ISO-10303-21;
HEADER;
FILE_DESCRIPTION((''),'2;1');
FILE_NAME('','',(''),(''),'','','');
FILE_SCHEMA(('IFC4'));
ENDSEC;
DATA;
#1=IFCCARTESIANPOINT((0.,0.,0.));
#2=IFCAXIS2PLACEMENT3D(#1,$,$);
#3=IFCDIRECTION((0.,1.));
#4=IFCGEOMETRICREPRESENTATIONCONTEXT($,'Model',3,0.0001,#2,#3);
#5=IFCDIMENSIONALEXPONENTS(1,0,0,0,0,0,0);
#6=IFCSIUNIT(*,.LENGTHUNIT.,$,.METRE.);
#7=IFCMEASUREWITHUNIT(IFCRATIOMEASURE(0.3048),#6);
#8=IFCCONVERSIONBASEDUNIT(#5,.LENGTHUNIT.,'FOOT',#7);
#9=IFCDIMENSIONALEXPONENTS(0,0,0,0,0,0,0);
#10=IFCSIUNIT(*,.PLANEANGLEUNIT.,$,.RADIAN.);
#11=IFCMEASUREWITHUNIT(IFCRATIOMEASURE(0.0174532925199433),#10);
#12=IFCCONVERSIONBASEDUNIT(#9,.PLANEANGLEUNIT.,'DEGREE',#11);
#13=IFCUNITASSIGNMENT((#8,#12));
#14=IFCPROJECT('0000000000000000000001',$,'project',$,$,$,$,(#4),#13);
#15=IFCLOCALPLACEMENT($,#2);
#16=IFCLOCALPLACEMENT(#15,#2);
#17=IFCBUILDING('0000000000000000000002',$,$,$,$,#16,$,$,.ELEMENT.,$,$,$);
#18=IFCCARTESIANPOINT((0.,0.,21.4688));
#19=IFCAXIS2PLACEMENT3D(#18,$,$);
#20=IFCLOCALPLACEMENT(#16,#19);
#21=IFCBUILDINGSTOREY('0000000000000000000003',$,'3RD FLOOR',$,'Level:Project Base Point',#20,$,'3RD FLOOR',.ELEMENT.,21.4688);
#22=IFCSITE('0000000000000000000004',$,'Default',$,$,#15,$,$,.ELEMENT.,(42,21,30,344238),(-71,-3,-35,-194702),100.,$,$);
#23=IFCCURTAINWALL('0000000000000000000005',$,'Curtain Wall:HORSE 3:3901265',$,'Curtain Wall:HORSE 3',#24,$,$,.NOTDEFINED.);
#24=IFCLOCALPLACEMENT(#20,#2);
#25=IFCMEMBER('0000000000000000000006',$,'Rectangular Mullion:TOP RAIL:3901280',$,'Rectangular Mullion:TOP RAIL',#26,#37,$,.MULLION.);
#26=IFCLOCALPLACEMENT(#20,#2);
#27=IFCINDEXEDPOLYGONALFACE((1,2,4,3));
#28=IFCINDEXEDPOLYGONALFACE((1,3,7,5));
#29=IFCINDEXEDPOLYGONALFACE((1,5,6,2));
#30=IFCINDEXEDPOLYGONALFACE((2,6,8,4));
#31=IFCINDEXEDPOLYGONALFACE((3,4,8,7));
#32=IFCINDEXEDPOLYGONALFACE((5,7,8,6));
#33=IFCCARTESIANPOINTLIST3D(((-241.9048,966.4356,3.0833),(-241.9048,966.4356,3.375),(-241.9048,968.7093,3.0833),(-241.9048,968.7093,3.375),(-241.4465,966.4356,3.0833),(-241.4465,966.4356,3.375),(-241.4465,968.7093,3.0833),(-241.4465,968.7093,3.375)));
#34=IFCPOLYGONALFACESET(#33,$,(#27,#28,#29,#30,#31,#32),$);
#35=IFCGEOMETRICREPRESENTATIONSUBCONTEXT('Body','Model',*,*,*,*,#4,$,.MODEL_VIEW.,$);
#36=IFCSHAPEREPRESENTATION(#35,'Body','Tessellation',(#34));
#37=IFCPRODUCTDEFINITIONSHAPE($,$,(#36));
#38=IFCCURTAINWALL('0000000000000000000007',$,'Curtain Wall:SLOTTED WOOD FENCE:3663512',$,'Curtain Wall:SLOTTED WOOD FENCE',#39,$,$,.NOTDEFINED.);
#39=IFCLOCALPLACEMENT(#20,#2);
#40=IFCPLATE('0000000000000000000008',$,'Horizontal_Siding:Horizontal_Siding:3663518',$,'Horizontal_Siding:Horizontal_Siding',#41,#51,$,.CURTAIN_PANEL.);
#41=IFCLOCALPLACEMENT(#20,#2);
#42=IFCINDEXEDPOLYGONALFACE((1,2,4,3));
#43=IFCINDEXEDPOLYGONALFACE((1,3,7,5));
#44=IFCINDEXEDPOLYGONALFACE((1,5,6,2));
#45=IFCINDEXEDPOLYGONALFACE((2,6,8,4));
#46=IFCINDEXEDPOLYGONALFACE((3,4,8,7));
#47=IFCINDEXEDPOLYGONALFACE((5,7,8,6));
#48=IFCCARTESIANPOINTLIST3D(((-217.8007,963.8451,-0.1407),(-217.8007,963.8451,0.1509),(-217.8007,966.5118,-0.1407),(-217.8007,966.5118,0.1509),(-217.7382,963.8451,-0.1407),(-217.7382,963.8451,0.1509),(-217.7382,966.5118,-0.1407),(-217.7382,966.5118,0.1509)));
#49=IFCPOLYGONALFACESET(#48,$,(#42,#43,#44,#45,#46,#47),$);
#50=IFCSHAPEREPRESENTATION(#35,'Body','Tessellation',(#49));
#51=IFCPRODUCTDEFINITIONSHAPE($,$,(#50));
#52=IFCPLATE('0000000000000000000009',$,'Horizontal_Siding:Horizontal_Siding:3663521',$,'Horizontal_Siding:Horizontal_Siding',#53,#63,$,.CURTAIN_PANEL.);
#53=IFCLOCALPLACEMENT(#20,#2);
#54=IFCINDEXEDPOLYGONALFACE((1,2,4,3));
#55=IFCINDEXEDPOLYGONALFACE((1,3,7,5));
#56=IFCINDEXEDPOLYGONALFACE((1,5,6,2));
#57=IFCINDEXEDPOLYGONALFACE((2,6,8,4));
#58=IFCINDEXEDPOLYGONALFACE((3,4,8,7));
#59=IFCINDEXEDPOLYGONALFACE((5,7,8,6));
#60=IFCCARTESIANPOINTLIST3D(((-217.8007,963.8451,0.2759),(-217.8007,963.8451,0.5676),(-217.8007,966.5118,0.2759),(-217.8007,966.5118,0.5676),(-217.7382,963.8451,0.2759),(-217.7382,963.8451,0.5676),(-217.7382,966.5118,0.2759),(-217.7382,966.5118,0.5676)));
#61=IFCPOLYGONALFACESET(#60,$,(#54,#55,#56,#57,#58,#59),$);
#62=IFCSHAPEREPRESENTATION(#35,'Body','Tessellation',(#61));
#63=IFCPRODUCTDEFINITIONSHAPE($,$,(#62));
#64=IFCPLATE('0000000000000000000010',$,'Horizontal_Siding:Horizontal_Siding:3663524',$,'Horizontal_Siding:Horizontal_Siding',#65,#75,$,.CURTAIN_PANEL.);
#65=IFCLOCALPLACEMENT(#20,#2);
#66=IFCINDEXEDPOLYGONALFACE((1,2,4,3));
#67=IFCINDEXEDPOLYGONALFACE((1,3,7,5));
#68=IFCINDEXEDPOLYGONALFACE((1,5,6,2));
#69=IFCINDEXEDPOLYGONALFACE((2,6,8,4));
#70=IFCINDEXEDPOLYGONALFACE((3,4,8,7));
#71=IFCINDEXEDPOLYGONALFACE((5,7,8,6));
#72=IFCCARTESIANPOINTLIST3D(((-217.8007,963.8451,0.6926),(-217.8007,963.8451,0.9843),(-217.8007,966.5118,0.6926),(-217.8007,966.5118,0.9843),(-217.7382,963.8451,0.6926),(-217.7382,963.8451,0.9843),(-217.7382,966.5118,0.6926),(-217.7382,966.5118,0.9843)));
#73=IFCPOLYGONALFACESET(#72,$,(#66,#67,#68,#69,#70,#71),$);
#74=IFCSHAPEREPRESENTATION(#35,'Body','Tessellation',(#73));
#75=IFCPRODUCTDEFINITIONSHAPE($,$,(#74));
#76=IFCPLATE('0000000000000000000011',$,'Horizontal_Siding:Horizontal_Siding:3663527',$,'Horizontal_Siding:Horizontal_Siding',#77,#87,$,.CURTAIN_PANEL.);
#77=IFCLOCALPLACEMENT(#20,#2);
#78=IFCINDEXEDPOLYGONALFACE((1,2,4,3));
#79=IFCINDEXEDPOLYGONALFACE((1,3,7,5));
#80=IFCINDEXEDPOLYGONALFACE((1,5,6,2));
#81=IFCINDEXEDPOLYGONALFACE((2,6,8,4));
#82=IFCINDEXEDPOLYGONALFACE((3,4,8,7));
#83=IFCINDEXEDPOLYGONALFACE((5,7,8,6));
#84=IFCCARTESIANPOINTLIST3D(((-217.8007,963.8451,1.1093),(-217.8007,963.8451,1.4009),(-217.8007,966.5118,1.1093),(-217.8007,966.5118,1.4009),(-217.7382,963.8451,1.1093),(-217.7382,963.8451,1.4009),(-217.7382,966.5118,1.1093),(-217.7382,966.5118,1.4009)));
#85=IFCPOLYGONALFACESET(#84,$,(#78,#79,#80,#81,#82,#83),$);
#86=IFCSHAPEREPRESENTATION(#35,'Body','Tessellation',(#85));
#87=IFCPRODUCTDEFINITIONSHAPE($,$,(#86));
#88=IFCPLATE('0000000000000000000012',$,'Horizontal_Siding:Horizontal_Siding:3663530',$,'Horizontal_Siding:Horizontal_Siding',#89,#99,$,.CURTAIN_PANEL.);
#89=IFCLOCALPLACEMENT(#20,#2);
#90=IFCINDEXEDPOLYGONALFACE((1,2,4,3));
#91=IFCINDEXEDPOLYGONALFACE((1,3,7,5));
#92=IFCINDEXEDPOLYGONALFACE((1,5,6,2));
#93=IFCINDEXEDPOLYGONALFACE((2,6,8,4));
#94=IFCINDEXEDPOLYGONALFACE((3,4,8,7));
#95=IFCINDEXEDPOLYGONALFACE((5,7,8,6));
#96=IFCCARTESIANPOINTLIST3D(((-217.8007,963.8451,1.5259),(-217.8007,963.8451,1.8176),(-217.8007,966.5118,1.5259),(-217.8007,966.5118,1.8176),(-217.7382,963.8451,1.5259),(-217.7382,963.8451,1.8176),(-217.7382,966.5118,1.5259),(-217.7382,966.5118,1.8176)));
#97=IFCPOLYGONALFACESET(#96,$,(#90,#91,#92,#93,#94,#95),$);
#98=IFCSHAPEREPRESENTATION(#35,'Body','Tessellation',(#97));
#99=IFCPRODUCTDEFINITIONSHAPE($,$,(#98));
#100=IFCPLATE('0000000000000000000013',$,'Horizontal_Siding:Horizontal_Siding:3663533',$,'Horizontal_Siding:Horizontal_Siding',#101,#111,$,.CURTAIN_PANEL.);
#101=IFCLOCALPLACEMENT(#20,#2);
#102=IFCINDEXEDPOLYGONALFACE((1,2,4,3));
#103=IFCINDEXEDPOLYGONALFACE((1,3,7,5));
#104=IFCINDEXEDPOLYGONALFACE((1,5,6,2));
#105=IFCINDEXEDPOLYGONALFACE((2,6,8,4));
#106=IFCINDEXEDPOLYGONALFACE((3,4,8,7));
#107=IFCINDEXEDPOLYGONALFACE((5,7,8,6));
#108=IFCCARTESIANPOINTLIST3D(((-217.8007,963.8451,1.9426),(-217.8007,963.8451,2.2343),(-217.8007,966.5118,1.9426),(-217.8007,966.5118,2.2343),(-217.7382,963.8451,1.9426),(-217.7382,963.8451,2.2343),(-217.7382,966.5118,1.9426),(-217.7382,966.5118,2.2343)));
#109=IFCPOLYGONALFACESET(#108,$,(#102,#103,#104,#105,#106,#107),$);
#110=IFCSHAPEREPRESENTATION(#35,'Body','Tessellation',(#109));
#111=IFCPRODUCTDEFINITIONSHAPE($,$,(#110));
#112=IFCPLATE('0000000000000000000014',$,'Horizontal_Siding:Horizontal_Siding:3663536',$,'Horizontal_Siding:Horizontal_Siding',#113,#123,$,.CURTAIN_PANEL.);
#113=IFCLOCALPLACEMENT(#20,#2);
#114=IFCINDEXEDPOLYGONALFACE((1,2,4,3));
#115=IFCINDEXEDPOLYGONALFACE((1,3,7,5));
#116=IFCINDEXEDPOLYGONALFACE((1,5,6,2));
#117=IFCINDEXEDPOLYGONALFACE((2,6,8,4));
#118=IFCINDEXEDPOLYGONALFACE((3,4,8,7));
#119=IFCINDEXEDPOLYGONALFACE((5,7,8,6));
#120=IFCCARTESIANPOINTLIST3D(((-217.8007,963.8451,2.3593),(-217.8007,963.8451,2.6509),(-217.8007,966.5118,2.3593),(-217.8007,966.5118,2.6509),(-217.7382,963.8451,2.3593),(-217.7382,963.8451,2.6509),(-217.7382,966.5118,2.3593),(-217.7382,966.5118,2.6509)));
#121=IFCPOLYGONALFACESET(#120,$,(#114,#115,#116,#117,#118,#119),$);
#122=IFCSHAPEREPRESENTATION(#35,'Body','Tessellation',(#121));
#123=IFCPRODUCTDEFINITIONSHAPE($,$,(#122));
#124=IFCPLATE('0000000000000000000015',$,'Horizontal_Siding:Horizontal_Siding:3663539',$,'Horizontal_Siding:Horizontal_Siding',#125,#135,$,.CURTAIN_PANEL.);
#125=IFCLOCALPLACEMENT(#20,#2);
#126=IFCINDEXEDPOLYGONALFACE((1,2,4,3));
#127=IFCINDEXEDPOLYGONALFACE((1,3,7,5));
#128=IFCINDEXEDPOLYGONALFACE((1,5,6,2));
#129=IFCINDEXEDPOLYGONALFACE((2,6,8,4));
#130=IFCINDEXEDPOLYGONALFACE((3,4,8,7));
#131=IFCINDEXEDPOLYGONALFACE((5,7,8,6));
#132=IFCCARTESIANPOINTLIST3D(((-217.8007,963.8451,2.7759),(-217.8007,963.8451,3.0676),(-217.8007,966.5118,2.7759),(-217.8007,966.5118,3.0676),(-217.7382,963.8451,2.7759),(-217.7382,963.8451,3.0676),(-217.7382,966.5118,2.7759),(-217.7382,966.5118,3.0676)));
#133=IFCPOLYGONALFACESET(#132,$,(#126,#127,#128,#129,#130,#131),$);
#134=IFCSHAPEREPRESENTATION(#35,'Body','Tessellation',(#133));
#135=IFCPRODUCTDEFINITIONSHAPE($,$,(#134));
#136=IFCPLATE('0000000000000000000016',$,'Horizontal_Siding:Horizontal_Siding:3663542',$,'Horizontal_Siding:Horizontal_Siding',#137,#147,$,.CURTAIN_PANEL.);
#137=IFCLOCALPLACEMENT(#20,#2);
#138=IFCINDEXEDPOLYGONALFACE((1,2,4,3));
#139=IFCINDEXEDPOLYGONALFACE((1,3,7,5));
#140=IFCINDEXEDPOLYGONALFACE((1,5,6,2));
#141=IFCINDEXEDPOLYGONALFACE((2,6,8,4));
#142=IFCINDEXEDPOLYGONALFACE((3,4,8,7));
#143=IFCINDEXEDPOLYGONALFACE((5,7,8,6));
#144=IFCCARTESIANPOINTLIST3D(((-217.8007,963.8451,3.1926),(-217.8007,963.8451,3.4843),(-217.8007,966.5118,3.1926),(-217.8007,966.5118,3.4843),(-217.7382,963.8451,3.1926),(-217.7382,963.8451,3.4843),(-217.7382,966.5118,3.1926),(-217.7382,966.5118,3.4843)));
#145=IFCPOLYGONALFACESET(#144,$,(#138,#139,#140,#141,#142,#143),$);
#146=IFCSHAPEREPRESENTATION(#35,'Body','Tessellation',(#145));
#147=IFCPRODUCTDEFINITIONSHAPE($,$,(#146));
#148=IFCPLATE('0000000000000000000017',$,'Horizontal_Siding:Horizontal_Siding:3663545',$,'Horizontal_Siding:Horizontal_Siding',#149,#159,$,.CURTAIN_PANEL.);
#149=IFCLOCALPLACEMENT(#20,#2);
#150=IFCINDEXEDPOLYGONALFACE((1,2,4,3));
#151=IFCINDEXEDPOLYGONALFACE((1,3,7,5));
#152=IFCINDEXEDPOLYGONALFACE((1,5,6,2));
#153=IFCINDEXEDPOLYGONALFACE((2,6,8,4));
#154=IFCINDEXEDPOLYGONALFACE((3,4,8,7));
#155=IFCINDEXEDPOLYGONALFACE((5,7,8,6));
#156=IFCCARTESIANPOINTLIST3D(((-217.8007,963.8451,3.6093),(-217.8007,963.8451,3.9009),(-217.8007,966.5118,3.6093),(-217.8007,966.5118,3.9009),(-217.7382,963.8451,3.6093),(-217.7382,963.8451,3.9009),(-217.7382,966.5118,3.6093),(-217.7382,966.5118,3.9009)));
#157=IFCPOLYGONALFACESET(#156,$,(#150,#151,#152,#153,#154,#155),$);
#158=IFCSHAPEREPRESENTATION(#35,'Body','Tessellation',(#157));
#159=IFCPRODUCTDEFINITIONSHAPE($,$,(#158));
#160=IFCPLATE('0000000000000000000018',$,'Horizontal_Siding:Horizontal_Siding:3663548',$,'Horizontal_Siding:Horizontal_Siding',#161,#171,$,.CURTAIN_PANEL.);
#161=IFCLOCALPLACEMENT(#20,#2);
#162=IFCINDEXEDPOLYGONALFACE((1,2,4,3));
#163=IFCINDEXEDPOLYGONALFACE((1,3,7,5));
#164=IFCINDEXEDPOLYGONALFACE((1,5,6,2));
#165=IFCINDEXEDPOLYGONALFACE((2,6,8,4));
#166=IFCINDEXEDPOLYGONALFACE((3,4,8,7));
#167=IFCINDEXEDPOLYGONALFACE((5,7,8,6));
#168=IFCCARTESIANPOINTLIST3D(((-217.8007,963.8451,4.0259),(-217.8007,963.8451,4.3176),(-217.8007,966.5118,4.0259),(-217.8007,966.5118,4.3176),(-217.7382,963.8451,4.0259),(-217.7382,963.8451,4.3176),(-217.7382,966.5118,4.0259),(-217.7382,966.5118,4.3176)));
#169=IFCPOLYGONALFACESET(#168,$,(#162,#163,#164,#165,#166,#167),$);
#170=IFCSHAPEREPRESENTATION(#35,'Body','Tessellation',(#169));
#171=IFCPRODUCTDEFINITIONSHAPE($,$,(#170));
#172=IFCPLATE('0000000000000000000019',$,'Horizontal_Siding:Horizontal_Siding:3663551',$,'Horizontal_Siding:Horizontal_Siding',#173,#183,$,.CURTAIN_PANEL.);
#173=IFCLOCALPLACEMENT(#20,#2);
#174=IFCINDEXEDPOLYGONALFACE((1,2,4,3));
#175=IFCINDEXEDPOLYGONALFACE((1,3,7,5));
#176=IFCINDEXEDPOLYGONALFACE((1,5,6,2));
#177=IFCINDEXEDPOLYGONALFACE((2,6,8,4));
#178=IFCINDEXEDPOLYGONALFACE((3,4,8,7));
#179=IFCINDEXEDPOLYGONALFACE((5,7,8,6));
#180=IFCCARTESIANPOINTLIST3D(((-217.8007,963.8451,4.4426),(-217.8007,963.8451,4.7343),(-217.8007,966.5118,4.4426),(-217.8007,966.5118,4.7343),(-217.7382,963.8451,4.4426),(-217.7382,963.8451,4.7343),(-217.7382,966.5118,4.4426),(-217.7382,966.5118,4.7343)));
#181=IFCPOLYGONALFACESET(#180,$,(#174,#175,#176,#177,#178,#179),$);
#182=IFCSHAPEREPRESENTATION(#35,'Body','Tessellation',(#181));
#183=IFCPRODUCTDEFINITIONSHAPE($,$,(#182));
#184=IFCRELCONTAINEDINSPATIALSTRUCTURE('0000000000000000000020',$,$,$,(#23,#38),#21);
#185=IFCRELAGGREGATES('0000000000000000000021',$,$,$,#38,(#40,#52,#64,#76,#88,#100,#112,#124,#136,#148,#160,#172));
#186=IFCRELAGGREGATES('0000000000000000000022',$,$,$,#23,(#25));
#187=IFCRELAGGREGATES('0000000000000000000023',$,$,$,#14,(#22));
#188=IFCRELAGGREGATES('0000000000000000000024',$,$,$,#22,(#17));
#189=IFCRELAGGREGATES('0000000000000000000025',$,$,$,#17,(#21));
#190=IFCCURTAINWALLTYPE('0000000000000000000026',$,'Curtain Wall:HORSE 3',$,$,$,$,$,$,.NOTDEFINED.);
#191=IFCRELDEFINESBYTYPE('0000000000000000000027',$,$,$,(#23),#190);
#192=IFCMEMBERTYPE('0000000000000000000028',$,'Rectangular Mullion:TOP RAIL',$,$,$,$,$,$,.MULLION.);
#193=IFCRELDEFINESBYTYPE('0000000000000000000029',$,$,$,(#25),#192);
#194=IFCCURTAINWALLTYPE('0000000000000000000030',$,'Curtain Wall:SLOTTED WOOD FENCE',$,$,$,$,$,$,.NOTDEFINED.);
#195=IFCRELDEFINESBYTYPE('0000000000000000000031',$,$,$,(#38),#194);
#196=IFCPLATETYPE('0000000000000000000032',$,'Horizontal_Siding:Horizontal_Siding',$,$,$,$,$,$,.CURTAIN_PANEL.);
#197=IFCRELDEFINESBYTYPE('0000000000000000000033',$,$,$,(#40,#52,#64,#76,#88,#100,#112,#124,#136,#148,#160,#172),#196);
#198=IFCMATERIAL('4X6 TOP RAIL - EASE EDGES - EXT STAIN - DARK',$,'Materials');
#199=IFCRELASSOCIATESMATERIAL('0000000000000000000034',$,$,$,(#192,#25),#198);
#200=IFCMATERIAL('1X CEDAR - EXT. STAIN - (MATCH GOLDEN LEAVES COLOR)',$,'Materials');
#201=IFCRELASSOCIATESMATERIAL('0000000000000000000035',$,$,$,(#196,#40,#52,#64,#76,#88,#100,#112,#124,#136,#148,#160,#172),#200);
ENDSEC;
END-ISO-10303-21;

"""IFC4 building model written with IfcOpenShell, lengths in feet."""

from ifc_helpers import new_model, entity, si_unit, converted_unit, direction, frame, origin, origin_2d_with_axis, place, context, subcontext, project, spatial, rectangle, extrude, source, transform, mapped, material, material_profile, profile_set, profile_usage, type_object, type_shapes, element, aggregate, save


model = new_model("IFC4")

# Units and contexts
model_context = context("Model", 3, precision=0.0001, world=origin(), true_north=direction((0.0, 1.0)))
body_context = subcontext(model_context, "Body", "Model", "MODEL_VIEW")
ifc_project = project(units=[converted_unit("LENGTHUNIT", "FOOT", entity("IfcRatioMeasure", 0.3048), si_unit("LENGTHUNIT", "METRE"), dimensions=[1, 0, 0, 0, 0, 0, 0]), converted_unit("PLANEANGLEUNIT", "DEGREE", entity("IfcRatioMeasure", 0.0174532925199433), si_unit("PLANEANGLEUNIT", "RADIAN"), dimensions=[0, 0, 0, 0, 0, 0, 0])], contexts=[model_context])

# Site, building, storey
site_placement = place(None, origin())
site = spatial("IfcSite", under=ifc_project, at=site_placement, Name="Default", CompositionType="ELEMENT", RefLatitude=(42, 21, 30, 344238), RefLongitude=(-71, -3, -35, -194702), RefElevation=100.0)
building_placement = place(site_placement, origin())
building = spatial("IfcBuilding", under=site, at=building_placement, CompositionType="ELEMENT")
storey_placement = place(building_placement, frame((0.0, 0.0, 21.4688)))
storey = spatial("IfcBuildingStorey", under=building, at=storey_placement, Name="3RD FLOOR", ObjectType="Level:Project Base Point", LongName="3RD FLOOR", CompositionType="ELEMENT", Elevation=21.4688)

# Curtain wall
curtain_wall_type_1 = type_object("IfcCurtainWallType", Name="Curtain Wall:HORSE 3", PredefinedType="NOTDEFINED")
curtain_wall_1_placement = place(storey_placement, frame((0.0, 0.0, -21.4688)))
curtain_wall_1 = element("IfcCurtainWall", 1, at=curtain_wall_1_placement, inside=storey, type_object=curtain_wall_type_1, Name="Curtain Wall:HORSE 3:3901265", ObjectType="Curtain Wall:HORSE 3", PredefinedType="NOTDEFINED")

# Shared definitions
curtain_wall_type_2 = type_object("IfcCurtainWallType", Name="Curtain Wall:SLOTTED WOOD FENCE", PredefinedType="NOTDEFINED")

# Member
ifc_material_1 = material(Name="4X6 TOP RAIL - EASE EDGES - EXT STAIN - DARK", Category="Materials")
ifc_material_profile_1 = material_profile(ifc_material_1, rectangle(XDim=0.4583, YDim=0.2917, at=origin_2d_with_axis()), Name="TOP RAIL")
ifc_profile_set_1 = profile_set([ifc_material_profile_1], Name="TOP RAIL")
ifc_profile_usage_1 = profile_usage(ifc_profile_set_1)
member_type_1 = type_object("IfcMemberType", Name="Rectangular Mullion:TOP RAIL", PredefinedType="MULLION", material=ifc_profile_set_1)
shared_shape_1 = source(origin(), body_context, "Body", "SweptSolid", [
    extrude(rectangle(XDim=0.4583, YDim=0.2917, at=origin_2d_with_axis()), frame((-0.1458, 0.0625, -2.2737), z_axis=(0.0, 0.0, 1.0), x_axis=(0.0, -1.0, 0.0)), (0.0, 0.0, 1.0), 2.2737),
])
type_shapes(member_type_1, [shared_shape_1])
member_1_placement = place(storey_placement, frame((-241.7382, 968.7093, 3.375), z_axis=(0.0, 1.0, 0.0), x_axis=(0.0, 0.0, 1.0)))
member_1 = element("IfcMember", 2, at=member_1_placement, type_object=member_type_1, material=ifc_profile_usage_1, Name="Rectangular Mullion:TOP RAIL:3901280", ObjectType="Rectangular Mullion:TOP RAIL", PredefinedType="MULLION", context=body_context, shape_type="MappedRepresentation", body=[
    mapped(shared_shape_1, transform((0.0, 0.0, 0.0), scale=1.0)),
])

# Curtain wall, plates
curtain_wall_2_placement = place(storey_placement, frame((0.0, 0.0, -21.4688)))
curtain_wall_2 = element("IfcCurtainWall", 3, at=curtain_wall_2_placement, inside=storey, type_object=curtain_wall_type_2, Name="Curtain Wall:SLOTTED WOOD FENCE:3663512", ObjectType="Curtain Wall:SLOTTED WOOD FENCE", PredefinedType="NOTDEFINED")
ifc_material_2 = material(Name="1X CEDAR - EXT. STAIN - (MATCH GOLDEN LEAVES COLOR)", Category="Materials")
plate_type_1 = type_object("IfcPlateType", Name="Horizontal_Siding:Horizontal_Siding", PredefinedType="CURTAIN_PANEL", material=ifc_material_2)
shared_shape_2 = source(origin(), body_context, "Body", "SweptSolid", [
    extrude(rectangle(XDim=2.6667, YDim=0.0625, at=origin_2d_with_axis()), frame((1.3333, 0.0312, 0.0), z_axis=(0.0, 0.0, 1.0), x_axis=(-1.0, 0.0, 0.0)), (0.0, 0.0, 1.0), 0.2917),
])
type_shapes(plate_type_1, [shared_shape_2])
plate_1_placement = place(curtain_wall_2_placement, frame((-217.8007, 966.5118, 21.328), z_axis=(0.0, 0.0, 1.0), x_axis=(0.0, -1.0, 0.0)))
plate_1 = element("IfcPlate", 4, at=plate_1_placement, type_object=plate_type_1, material=ifc_material_2, Name="Horizontal_Siding:Horizontal_Siding:3663518", ObjectType="Horizontal_Siding:Horizontal_Siding", PredefinedType="CURTAIN_PANEL", context=body_context, shape_type="MappedRepresentation", body=[
    mapped(shared_shape_2, transform((0.0, 0.0, 0.0), scale=1.0)),
])
plate_2_placement = place(curtain_wall_2_placement, frame((-217.8007, 966.5118, 21.7447), z_axis=(0.0, 0.0, 1.0), x_axis=(0.0, -1.0, 0.0)))
plate_2 = element("IfcPlate", 5, at=plate_2_placement, type_object=plate_type_1, material=ifc_material_2, Name="Horizontal_Siding:Horizontal_Siding:3663521", ObjectType="Horizontal_Siding:Horizontal_Siding", PredefinedType="CURTAIN_PANEL", context=body_context, shape_type="MappedRepresentation", body=[
    mapped(shared_shape_2, transform((0.0, 0.0, 0.0), scale=1.0)),
])
plate_3_placement = place(curtain_wall_2_placement, frame((-217.8007, 966.5118, 22.1613), z_axis=(0.0, 0.0, 1.0), x_axis=(0.0, -1.0, 0.0)))
plate_3 = element("IfcPlate", 6, at=plate_3_placement, type_object=plate_type_1, material=ifc_material_2, Name="Horizontal_Siding:Horizontal_Siding:3663524", ObjectType="Horizontal_Siding:Horizontal_Siding", PredefinedType="CURTAIN_PANEL", context=body_context, shape_type="MappedRepresentation", body=[
    mapped(shared_shape_2, transform((0.0, 0.0, 0.0), scale=1.0)),
])
plate_4_placement = place(curtain_wall_2_placement, frame((-217.8007, 966.5118, 22.578), z_axis=(0.0, 0.0, 1.0), x_axis=(0.0, -1.0, 0.0)))
plate_4 = element("IfcPlate", 7, at=plate_4_placement, type_object=plate_type_1, material=ifc_material_2, Name="Horizontal_Siding:Horizontal_Siding:3663527", ObjectType="Horizontal_Siding:Horizontal_Siding", PredefinedType="CURTAIN_PANEL", context=body_context, shape_type="MappedRepresentation", body=[
    mapped(shared_shape_2, transform((0.0, 0.0, 0.0), scale=1.0)),
])
plate_5_placement = place(curtain_wall_2_placement, frame((-217.8007, 966.5118, 22.9947), z_axis=(0.0, 0.0, 1.0), x_axis=(0.0, -1.0, 0.0)))
plate_5 = element("IfcPlate", 8, at=plate_5_placement, type_object=plate_type_1, material=ifc_material_2, Name="Horizontal_Siding:Horizontal_Siding:3663530", ObjectType="Horizontal_Siding:Horizontal_Siding", PredefinedType="CURTAIN_PANEL", context=body_context, shape_type="MappedRepresentation", body=[
    mapped(shared_shape_2, transform((0.0, 0.0, 0.0), scale=1.0)),
])
plate_6_placement = place(curtain_wall_2_placement, frame((-217.8007, 966.5118, 23.4113), z_axis=(0.0, 0.0, 1.0), x_axis=(0.0, -1.0, 0.0)))
plate_6 = element("IfcPlate", 9, at=plate_6_placement, type_object=plate_type_1, material=ifc_material_2, Name="Horizontal_Siding:Horizontal_Siding:3663533", ObjectType="Horizontal_Siding:Horizontal_Siding", PredefinedType="CURTAIN_PANEL", context=body_context, shape_type="MappedRepresentation", body=[
    mapped(shared_shape_2, transform((0.0, 0.0, 0.0), scale=1.0)),
])
plate_7_placement = place(curtain_wall_2_placement, frame((-217.8007, 966.5118, 23.828), z_axis=(0.0, 0.0, 1.0), x_axis=(0.0, -1.0, 0.0)))
plate_7 = element("IfcPlate", 10, at=plate_7_placement, type_object=plate_type_1, material=ifc_material_2, Name="Horizontal_Siding:Horizontal_Siding:3663536", ObjectType="Horizontal_Siding:Horizontal_Siding", PredefinedType="CURTAIN_PANEL", context=body_context, shape_type="MappedRepresentation", body=[
    mapped(shared_shape_2, transform((0.0, 0.0, 0.0), scale=1.0)),
])
plate_8_placement = place(curtain_wall_2_placement, frame((-217.8007, 966.5118, 24.2447), z_axis=(0.0, 0.0, 1.0), x_axis=(0.0, -1.0, 0.0)))
plate_8 = element("IfcPlate", 11, at=plate_8_placement, type_object=plate_type_1, material=ifc_material_2, Name="Horizontal_Siding:Horizontal_Siding:3663539", ObjectType="Horizontal_Siding:Horizontal_Siding", PredefinedType="CURTAIN_PANEL", context=body_context, shape_type="MappedRepresentation", body=[
    mapped(shared_shape_2, transform((0.0, 0.0, 0.0), scale=1.0)),
])
plate_9_placement = place(curtain_wall_2_placement, frame((-217.8007, 966.5118, 24.6613), z_axis=(0.0, 0.0, 1.0), x_axis=(0.0, -1.0, 0.0)))
plate_9 = element("IfcPlate", 12, at=plate_9_placement, type_object=plate_type_1, material=ifc_material_2, Name="Horizontal_Siding:Horizontal_Siding:3663542", ObjectType="Horizontal_Siding:Horizontal_Siding", PredefinedType="CURTAIN_PANEL", context=body_context, shape_type="MappedRepresentation", body=[
    mapped(shared_shape_2, transform((0.0, 0.0, 0.0), scale=1.0)),
])
plate_10_placement = place(curtain_wall_2_placement, frame((-217.8007, 966.5118, 25.078), z_axis=(0.0, 0.0, 1.0), x_axis=(0.0, -1.0, 0.0)))
plate_10 = element("IfcPlate", 13, at=plate_10_placement, type_object=plate_type_1, material=ifc_material_2, Name="Horizontal_Siding:Horizontal_Siding:3663545", ObjectType="Horizontal_Siding:Horizontal_Siding", PredefinedType="CURTAIN_PANEL", context=body_context, shape_type="MappedRepresentation", body=[
    mapped(shared_shape_2, transform((0.0, 0.0, 0.0), scale=1.0)),
])
plate_11_placement = place(curtain_wall_2_placement, frame((-217.8007, 966.5118, 25.4947), z_axis=(0.0, 0.0, 1.0), x_axis=(0.0, -1.0, 0.0)))
plate_11 = element("IfcPlate", 14, at=plate_11_placement, type_object=plate_type_1, material=ifc_material_2, Name="Horizontal_Siding:Horizontal_Siding:3663548", ObjectType="Horizontal_Siding:Horizontal_Siding", PredefinedType="CURTAIN_PANEL", context=body_context, shape_type="MappedRepresentation", body=[
    mapped(shared_shape_2, transform((0.0, 0.0, 0.0), scale=1.0)),
])
plate_12_placement = place(curtain_wall_2_placement, frame((-217.8007, 966.5118, 25.9113), z_axis=(0.0, 0.0, 1.0), x_axis=(0.0, -1.0, 0.0)))
plate_12 = element("IfcPlate", 15, at=plate_12_placement, type_object=plate_type_1, material=ifc_material_2, Name="Horizontal_Siding:Horizontal_Siding:3663551", ObjectType="Horizontal_Siding:Horizontal_Siding", PredefinedType="CURTAIN_PANEL", context=body_context, shape_type="MappedRepresentation", body=[
    mapped(shared_shape_2, transform((0.0, 0.0, 0.0), scale=1.0)),
])
aggregate(curtain_wall_2, [plate_1, plate_2, plate_3, plate_4, plate_5, plate_6, plate_7, plate_8, plate_9, plate_10, plate_11, plate_12])

aggregate(curtain_wall_1, [member_1])

save(model, "model.ifc")
